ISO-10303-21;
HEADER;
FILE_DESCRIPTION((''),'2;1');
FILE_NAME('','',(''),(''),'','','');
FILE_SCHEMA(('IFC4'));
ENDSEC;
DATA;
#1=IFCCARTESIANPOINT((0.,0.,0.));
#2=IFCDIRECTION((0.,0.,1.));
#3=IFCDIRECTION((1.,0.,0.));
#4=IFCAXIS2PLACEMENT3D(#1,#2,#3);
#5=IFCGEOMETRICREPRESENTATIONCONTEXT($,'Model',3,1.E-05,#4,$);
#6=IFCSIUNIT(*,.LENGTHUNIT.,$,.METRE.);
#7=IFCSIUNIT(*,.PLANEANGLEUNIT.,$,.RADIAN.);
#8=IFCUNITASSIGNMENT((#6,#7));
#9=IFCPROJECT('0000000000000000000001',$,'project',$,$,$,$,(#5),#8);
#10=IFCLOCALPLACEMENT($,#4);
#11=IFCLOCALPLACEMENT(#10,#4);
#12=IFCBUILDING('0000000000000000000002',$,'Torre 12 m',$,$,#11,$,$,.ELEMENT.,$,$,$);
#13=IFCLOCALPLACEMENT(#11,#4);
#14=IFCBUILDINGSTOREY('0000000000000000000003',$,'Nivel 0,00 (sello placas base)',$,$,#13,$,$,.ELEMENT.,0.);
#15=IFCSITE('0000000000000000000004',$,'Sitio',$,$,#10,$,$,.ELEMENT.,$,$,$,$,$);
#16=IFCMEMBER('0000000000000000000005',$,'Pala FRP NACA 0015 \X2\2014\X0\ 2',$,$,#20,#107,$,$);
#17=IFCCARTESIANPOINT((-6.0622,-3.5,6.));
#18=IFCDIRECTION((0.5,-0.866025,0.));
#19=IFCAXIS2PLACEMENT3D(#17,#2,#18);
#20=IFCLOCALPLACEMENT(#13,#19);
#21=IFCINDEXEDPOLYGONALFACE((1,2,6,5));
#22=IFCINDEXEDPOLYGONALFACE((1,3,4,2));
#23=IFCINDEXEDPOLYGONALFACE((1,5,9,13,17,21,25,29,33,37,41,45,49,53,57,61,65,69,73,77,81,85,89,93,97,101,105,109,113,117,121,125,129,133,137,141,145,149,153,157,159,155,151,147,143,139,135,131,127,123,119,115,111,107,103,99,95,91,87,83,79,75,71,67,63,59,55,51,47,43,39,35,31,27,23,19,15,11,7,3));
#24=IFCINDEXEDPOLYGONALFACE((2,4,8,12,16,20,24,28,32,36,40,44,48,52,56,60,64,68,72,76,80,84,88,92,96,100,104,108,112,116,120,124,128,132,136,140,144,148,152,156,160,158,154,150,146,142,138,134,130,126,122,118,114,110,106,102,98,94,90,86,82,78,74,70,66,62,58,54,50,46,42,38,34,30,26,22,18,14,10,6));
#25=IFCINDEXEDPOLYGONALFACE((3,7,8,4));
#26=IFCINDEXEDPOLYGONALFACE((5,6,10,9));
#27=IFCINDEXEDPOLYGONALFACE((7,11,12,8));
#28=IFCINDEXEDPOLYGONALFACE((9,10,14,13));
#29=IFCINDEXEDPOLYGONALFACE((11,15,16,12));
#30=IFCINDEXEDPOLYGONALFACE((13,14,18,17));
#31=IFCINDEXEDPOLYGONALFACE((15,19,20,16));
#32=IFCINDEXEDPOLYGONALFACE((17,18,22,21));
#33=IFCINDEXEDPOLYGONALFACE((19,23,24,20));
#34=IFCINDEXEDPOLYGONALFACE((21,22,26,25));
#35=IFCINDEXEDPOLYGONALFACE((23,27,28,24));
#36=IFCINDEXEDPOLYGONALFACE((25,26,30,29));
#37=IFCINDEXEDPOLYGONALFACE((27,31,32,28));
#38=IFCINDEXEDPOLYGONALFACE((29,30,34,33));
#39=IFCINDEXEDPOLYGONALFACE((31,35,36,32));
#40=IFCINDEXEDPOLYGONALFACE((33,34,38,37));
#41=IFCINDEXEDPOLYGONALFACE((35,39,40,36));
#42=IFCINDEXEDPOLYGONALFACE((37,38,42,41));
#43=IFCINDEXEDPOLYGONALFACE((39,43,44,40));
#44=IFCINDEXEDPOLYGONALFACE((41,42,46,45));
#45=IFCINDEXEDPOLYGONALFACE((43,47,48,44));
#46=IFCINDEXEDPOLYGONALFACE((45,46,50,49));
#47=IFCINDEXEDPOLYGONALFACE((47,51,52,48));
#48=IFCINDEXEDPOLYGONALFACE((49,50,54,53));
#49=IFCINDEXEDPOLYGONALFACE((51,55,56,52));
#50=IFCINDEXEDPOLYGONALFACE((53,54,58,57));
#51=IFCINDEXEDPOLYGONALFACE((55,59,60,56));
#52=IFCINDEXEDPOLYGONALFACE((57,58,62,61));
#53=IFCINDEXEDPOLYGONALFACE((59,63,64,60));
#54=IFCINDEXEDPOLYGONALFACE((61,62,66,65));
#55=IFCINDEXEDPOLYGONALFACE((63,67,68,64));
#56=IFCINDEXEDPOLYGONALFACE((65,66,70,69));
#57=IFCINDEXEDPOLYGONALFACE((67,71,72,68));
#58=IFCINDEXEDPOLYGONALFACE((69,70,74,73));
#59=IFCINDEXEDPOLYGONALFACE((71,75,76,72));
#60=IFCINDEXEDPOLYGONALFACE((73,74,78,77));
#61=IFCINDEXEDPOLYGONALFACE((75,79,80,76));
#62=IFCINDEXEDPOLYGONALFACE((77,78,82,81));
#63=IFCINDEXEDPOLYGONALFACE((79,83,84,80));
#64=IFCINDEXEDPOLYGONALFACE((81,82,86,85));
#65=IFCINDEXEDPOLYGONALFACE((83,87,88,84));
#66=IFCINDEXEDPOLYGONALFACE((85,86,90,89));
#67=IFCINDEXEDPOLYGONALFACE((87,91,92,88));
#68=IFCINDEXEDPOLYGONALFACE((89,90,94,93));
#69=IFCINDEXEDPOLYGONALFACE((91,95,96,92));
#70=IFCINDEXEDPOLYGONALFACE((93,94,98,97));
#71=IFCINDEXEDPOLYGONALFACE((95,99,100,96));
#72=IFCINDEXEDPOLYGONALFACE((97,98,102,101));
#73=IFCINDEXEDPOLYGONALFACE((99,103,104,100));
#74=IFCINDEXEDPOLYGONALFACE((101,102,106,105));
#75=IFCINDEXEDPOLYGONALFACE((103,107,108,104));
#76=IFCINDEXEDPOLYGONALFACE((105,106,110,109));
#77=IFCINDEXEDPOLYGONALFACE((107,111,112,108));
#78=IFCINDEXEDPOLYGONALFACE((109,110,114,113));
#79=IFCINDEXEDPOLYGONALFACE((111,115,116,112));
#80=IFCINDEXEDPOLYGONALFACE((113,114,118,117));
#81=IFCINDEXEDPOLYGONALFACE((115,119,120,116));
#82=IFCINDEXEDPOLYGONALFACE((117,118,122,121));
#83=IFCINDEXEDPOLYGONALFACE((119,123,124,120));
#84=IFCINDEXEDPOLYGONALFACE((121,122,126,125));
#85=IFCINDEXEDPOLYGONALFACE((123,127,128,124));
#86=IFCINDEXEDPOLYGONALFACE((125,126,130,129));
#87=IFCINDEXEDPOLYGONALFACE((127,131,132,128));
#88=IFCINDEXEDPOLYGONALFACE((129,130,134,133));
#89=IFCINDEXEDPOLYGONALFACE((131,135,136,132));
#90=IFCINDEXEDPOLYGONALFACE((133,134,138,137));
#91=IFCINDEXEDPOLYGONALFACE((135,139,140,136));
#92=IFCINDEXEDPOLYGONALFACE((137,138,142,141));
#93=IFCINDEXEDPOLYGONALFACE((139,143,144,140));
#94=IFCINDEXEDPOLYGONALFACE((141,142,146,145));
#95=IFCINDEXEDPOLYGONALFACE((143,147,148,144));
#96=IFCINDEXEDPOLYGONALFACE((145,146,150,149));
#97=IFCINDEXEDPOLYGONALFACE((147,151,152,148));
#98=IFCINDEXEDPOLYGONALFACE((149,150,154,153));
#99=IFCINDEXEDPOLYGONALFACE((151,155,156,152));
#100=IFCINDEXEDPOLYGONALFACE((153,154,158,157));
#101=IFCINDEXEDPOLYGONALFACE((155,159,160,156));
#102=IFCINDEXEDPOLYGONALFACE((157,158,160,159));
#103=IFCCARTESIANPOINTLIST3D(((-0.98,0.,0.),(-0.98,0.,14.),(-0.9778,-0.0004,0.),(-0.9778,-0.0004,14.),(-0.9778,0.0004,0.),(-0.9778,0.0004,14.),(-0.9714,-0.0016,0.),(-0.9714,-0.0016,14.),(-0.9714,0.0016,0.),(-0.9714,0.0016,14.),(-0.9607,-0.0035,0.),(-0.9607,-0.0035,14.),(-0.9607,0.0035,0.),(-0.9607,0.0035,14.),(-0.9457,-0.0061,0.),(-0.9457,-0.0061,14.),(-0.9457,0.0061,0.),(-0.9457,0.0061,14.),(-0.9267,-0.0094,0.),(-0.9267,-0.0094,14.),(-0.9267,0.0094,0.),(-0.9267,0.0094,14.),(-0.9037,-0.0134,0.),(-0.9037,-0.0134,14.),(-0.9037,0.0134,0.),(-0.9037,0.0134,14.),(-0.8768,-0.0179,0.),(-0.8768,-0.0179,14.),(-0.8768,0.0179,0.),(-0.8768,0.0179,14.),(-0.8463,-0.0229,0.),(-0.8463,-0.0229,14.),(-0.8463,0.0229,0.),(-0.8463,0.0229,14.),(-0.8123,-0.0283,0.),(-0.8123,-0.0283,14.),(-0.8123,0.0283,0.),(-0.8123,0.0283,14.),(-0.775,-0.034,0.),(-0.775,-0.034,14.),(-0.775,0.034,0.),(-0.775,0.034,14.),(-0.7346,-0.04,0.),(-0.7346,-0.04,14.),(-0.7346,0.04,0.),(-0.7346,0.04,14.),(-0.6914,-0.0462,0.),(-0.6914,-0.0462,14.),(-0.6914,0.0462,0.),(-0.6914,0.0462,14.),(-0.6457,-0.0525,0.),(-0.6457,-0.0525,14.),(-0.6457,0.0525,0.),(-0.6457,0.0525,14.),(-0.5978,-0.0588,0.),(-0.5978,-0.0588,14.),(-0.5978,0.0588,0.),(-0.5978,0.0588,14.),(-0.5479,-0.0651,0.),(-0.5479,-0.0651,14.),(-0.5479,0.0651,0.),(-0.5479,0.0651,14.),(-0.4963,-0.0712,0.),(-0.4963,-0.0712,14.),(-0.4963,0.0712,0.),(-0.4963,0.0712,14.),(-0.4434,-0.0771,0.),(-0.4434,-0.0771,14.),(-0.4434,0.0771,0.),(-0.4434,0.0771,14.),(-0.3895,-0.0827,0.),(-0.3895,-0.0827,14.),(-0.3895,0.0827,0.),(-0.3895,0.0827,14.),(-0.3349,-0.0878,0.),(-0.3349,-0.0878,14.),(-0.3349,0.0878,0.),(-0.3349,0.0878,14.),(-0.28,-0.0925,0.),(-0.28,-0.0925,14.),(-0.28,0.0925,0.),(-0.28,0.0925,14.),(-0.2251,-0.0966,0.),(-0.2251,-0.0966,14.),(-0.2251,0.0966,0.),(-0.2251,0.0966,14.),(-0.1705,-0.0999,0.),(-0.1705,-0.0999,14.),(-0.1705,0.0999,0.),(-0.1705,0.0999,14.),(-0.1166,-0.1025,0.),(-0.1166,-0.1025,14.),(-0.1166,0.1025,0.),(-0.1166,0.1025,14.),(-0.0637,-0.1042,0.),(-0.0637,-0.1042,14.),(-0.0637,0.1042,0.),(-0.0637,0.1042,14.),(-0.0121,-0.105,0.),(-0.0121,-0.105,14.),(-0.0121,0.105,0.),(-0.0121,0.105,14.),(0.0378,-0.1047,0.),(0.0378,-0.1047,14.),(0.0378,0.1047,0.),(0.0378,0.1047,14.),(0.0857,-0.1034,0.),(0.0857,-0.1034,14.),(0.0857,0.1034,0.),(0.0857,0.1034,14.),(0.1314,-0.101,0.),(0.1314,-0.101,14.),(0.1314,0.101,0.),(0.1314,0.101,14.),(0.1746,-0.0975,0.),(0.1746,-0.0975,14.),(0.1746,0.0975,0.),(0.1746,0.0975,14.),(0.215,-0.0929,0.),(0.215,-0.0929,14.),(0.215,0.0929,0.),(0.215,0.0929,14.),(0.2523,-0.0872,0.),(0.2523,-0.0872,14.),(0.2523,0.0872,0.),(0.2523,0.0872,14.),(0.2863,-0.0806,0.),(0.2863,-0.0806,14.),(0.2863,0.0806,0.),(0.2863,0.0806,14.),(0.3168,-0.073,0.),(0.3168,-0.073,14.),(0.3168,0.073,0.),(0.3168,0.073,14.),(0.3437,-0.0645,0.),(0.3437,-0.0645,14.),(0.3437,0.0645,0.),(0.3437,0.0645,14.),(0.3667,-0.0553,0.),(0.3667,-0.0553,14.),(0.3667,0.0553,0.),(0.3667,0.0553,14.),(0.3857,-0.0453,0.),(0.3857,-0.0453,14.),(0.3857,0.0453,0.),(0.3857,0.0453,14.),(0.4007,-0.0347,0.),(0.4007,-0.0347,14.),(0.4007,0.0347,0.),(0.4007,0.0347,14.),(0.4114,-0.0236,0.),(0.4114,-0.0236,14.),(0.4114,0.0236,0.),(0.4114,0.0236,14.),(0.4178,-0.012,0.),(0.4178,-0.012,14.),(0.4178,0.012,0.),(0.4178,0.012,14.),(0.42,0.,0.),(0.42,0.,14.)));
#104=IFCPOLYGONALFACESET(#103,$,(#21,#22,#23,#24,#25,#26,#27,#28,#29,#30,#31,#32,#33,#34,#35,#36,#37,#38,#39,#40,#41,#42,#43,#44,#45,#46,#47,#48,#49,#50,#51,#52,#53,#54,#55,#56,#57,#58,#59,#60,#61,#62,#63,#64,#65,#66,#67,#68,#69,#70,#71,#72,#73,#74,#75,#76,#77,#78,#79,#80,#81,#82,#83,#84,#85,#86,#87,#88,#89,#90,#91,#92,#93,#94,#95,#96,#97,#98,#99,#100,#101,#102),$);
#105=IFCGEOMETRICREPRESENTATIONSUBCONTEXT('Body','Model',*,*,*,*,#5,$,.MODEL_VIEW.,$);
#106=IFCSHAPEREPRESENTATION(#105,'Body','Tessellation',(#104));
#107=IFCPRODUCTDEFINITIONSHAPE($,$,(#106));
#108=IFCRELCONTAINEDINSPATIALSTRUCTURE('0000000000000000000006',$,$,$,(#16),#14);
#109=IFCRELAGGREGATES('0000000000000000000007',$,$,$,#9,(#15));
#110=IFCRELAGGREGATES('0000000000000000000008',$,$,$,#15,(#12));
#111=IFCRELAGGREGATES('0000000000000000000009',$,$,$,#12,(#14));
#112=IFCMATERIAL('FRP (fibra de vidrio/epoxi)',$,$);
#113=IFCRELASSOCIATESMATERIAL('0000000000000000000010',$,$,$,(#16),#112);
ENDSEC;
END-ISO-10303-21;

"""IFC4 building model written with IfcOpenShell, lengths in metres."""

from ifc_helpers import new_model, si_unit, frame, origin, origin_with_axes, place, context, subcontext, project, spatial, polyline, outline, extrude, material, element, save


model = new_model("IFC4")

# Units and contexts
model_context = context("Model", 3, precision=1e-05, world=origin_with_axes())
body_context = subcontext(model_context, "Body", "Model", "MODEL_VIEW")
ifc_project = project(units=[si_unit("LENGTHUNIT", "METRE"), si_unit("PLANEANGLEUNIT", "RADIAN")], contexts=[model_context])

# Site, building, storey
site_placement = place(None, origin_with_axes())
site = spatial("IfcSite", under=ifc_project, at=site_placement, Name="Sitio", CompositionType="ELEMENT")
building_placement = place(site_placement, origin_with_axes())
building = spatial("IfcBuilding", under=site, at=building_placement, Name="Torre 12 m", CompositionType="ELEMENT")
storey_placement = place(building_placement, origin_with_axes())
storey = spatial("IfcBuildingStorey", under=building, at=storey_placement, Name="Nivel 0,00 (sello placas base)", CompositionType="ELEMENT", Elevation=0.0)

# Member
ifc_material_1 = material(Name="FRP (fibra de vidrio/epoxi)")
member_1_placement = place(storey_placement, frame((-6.0622, -3.5, 6.0), z_axis=(0.0, 0.0, 1.0), x_axis=(0.5, -0.866025, 0.0)))
element("IfcMember", 1, at=member_1_placement, inside=storey, material=ifc_material_1, Name="Pala FRP NACA 0015 — 2", context=body_context, shape_type="SweptSolid", body=[
    extrude(outline(polyline([(0.42, 0.0), (0.4178, 0.012), (0.4114, 0.0236), (0.4007, 0.0347), (0.3857, 0.0453), (0.3667, 0.0553), (0.3437, 0.0645), (0.3168, 0.073), (0.2863, 0.0806), (0.2523, 0.0872), (0.215, 0.0929), (0.1746, 0.0975), (0.1314, 0.101), (0.0857, 0.1034), (0.0378, 0.1047), (-0.0121, 0.105), (-0.0637, 0.1042), (-0.1166, 0.1025), (-0.1705, 0.0999), (-0.2251, 0.0966), (-0.28, 0.0925), (-0.3349, 0.0878), (-0.3895, 0.0827), (-0.4434, 0.0771), (-0.4963, 0.0712), (-0.5479, 0.0651), (-0.5978, 0.0588), (-0.6457, 0.0525), (-0.6914, 0.0462), (-0.7346, 0.04), (-0.775, 0.034), (-0.8123, 0.0283), (-0.8463, 0.0229), (-0.8768, 0.0179), (-0.9037, 0.0134), (-0.9267, 0.0094), (-0.9457, 0.0061), (-0.9607, 0.0035), (-0.9714, 0.0016), (-0.9778, 0.0004), (-0.98, 0.0), (-0.9778, -0.0004), (-0.9714, -0.0016), (-0.9607, -0.0035), (-0.9457, -0.0061), (-0.9267, -0.0094), (-0.9037, -0.0134), (-0.8768, -0.0179), (-0.8463, -0.0229), (-0.8123, -0.0283), (-0.775, -0.034), (-0.7346, -0.04), (-0.6914, -0.0462), (-0.6457, -0.0525), (-0.5978, -0.0588), (-0.5479, -0.0651), (-0.4963, -0.0712), (-0.4434, -0.0771), (-0.3895, -0.0827), (-0.3349, -0.0878), (-0.28, -0.0925), (-0.2251, -0.0966), (-0.1705, -0.0999), (-0.1166, -0.1025), (-0.0637, -0.1042), (-0.0121, -0.105), (0.0378, -0.1047), (0.0857, -0.1034), (0.1314, -0.101), (0.1746, -0.0975), (0.215, -0.0929), (0.2523, -0.0872), (0.2863, -0.0806), (0.3168, -0.073), (0.3437, -0.0645), (0.3667, -0.0553), (0.3857, -0.0453), (0.4007, -0.0347), (0.4114, -0.0236), (0.4178, -0.012), (0.42, 0.0)])), origin(), (0.0, 0.0, 1.0), 14.0),
])

save(model, "model.ifc")
